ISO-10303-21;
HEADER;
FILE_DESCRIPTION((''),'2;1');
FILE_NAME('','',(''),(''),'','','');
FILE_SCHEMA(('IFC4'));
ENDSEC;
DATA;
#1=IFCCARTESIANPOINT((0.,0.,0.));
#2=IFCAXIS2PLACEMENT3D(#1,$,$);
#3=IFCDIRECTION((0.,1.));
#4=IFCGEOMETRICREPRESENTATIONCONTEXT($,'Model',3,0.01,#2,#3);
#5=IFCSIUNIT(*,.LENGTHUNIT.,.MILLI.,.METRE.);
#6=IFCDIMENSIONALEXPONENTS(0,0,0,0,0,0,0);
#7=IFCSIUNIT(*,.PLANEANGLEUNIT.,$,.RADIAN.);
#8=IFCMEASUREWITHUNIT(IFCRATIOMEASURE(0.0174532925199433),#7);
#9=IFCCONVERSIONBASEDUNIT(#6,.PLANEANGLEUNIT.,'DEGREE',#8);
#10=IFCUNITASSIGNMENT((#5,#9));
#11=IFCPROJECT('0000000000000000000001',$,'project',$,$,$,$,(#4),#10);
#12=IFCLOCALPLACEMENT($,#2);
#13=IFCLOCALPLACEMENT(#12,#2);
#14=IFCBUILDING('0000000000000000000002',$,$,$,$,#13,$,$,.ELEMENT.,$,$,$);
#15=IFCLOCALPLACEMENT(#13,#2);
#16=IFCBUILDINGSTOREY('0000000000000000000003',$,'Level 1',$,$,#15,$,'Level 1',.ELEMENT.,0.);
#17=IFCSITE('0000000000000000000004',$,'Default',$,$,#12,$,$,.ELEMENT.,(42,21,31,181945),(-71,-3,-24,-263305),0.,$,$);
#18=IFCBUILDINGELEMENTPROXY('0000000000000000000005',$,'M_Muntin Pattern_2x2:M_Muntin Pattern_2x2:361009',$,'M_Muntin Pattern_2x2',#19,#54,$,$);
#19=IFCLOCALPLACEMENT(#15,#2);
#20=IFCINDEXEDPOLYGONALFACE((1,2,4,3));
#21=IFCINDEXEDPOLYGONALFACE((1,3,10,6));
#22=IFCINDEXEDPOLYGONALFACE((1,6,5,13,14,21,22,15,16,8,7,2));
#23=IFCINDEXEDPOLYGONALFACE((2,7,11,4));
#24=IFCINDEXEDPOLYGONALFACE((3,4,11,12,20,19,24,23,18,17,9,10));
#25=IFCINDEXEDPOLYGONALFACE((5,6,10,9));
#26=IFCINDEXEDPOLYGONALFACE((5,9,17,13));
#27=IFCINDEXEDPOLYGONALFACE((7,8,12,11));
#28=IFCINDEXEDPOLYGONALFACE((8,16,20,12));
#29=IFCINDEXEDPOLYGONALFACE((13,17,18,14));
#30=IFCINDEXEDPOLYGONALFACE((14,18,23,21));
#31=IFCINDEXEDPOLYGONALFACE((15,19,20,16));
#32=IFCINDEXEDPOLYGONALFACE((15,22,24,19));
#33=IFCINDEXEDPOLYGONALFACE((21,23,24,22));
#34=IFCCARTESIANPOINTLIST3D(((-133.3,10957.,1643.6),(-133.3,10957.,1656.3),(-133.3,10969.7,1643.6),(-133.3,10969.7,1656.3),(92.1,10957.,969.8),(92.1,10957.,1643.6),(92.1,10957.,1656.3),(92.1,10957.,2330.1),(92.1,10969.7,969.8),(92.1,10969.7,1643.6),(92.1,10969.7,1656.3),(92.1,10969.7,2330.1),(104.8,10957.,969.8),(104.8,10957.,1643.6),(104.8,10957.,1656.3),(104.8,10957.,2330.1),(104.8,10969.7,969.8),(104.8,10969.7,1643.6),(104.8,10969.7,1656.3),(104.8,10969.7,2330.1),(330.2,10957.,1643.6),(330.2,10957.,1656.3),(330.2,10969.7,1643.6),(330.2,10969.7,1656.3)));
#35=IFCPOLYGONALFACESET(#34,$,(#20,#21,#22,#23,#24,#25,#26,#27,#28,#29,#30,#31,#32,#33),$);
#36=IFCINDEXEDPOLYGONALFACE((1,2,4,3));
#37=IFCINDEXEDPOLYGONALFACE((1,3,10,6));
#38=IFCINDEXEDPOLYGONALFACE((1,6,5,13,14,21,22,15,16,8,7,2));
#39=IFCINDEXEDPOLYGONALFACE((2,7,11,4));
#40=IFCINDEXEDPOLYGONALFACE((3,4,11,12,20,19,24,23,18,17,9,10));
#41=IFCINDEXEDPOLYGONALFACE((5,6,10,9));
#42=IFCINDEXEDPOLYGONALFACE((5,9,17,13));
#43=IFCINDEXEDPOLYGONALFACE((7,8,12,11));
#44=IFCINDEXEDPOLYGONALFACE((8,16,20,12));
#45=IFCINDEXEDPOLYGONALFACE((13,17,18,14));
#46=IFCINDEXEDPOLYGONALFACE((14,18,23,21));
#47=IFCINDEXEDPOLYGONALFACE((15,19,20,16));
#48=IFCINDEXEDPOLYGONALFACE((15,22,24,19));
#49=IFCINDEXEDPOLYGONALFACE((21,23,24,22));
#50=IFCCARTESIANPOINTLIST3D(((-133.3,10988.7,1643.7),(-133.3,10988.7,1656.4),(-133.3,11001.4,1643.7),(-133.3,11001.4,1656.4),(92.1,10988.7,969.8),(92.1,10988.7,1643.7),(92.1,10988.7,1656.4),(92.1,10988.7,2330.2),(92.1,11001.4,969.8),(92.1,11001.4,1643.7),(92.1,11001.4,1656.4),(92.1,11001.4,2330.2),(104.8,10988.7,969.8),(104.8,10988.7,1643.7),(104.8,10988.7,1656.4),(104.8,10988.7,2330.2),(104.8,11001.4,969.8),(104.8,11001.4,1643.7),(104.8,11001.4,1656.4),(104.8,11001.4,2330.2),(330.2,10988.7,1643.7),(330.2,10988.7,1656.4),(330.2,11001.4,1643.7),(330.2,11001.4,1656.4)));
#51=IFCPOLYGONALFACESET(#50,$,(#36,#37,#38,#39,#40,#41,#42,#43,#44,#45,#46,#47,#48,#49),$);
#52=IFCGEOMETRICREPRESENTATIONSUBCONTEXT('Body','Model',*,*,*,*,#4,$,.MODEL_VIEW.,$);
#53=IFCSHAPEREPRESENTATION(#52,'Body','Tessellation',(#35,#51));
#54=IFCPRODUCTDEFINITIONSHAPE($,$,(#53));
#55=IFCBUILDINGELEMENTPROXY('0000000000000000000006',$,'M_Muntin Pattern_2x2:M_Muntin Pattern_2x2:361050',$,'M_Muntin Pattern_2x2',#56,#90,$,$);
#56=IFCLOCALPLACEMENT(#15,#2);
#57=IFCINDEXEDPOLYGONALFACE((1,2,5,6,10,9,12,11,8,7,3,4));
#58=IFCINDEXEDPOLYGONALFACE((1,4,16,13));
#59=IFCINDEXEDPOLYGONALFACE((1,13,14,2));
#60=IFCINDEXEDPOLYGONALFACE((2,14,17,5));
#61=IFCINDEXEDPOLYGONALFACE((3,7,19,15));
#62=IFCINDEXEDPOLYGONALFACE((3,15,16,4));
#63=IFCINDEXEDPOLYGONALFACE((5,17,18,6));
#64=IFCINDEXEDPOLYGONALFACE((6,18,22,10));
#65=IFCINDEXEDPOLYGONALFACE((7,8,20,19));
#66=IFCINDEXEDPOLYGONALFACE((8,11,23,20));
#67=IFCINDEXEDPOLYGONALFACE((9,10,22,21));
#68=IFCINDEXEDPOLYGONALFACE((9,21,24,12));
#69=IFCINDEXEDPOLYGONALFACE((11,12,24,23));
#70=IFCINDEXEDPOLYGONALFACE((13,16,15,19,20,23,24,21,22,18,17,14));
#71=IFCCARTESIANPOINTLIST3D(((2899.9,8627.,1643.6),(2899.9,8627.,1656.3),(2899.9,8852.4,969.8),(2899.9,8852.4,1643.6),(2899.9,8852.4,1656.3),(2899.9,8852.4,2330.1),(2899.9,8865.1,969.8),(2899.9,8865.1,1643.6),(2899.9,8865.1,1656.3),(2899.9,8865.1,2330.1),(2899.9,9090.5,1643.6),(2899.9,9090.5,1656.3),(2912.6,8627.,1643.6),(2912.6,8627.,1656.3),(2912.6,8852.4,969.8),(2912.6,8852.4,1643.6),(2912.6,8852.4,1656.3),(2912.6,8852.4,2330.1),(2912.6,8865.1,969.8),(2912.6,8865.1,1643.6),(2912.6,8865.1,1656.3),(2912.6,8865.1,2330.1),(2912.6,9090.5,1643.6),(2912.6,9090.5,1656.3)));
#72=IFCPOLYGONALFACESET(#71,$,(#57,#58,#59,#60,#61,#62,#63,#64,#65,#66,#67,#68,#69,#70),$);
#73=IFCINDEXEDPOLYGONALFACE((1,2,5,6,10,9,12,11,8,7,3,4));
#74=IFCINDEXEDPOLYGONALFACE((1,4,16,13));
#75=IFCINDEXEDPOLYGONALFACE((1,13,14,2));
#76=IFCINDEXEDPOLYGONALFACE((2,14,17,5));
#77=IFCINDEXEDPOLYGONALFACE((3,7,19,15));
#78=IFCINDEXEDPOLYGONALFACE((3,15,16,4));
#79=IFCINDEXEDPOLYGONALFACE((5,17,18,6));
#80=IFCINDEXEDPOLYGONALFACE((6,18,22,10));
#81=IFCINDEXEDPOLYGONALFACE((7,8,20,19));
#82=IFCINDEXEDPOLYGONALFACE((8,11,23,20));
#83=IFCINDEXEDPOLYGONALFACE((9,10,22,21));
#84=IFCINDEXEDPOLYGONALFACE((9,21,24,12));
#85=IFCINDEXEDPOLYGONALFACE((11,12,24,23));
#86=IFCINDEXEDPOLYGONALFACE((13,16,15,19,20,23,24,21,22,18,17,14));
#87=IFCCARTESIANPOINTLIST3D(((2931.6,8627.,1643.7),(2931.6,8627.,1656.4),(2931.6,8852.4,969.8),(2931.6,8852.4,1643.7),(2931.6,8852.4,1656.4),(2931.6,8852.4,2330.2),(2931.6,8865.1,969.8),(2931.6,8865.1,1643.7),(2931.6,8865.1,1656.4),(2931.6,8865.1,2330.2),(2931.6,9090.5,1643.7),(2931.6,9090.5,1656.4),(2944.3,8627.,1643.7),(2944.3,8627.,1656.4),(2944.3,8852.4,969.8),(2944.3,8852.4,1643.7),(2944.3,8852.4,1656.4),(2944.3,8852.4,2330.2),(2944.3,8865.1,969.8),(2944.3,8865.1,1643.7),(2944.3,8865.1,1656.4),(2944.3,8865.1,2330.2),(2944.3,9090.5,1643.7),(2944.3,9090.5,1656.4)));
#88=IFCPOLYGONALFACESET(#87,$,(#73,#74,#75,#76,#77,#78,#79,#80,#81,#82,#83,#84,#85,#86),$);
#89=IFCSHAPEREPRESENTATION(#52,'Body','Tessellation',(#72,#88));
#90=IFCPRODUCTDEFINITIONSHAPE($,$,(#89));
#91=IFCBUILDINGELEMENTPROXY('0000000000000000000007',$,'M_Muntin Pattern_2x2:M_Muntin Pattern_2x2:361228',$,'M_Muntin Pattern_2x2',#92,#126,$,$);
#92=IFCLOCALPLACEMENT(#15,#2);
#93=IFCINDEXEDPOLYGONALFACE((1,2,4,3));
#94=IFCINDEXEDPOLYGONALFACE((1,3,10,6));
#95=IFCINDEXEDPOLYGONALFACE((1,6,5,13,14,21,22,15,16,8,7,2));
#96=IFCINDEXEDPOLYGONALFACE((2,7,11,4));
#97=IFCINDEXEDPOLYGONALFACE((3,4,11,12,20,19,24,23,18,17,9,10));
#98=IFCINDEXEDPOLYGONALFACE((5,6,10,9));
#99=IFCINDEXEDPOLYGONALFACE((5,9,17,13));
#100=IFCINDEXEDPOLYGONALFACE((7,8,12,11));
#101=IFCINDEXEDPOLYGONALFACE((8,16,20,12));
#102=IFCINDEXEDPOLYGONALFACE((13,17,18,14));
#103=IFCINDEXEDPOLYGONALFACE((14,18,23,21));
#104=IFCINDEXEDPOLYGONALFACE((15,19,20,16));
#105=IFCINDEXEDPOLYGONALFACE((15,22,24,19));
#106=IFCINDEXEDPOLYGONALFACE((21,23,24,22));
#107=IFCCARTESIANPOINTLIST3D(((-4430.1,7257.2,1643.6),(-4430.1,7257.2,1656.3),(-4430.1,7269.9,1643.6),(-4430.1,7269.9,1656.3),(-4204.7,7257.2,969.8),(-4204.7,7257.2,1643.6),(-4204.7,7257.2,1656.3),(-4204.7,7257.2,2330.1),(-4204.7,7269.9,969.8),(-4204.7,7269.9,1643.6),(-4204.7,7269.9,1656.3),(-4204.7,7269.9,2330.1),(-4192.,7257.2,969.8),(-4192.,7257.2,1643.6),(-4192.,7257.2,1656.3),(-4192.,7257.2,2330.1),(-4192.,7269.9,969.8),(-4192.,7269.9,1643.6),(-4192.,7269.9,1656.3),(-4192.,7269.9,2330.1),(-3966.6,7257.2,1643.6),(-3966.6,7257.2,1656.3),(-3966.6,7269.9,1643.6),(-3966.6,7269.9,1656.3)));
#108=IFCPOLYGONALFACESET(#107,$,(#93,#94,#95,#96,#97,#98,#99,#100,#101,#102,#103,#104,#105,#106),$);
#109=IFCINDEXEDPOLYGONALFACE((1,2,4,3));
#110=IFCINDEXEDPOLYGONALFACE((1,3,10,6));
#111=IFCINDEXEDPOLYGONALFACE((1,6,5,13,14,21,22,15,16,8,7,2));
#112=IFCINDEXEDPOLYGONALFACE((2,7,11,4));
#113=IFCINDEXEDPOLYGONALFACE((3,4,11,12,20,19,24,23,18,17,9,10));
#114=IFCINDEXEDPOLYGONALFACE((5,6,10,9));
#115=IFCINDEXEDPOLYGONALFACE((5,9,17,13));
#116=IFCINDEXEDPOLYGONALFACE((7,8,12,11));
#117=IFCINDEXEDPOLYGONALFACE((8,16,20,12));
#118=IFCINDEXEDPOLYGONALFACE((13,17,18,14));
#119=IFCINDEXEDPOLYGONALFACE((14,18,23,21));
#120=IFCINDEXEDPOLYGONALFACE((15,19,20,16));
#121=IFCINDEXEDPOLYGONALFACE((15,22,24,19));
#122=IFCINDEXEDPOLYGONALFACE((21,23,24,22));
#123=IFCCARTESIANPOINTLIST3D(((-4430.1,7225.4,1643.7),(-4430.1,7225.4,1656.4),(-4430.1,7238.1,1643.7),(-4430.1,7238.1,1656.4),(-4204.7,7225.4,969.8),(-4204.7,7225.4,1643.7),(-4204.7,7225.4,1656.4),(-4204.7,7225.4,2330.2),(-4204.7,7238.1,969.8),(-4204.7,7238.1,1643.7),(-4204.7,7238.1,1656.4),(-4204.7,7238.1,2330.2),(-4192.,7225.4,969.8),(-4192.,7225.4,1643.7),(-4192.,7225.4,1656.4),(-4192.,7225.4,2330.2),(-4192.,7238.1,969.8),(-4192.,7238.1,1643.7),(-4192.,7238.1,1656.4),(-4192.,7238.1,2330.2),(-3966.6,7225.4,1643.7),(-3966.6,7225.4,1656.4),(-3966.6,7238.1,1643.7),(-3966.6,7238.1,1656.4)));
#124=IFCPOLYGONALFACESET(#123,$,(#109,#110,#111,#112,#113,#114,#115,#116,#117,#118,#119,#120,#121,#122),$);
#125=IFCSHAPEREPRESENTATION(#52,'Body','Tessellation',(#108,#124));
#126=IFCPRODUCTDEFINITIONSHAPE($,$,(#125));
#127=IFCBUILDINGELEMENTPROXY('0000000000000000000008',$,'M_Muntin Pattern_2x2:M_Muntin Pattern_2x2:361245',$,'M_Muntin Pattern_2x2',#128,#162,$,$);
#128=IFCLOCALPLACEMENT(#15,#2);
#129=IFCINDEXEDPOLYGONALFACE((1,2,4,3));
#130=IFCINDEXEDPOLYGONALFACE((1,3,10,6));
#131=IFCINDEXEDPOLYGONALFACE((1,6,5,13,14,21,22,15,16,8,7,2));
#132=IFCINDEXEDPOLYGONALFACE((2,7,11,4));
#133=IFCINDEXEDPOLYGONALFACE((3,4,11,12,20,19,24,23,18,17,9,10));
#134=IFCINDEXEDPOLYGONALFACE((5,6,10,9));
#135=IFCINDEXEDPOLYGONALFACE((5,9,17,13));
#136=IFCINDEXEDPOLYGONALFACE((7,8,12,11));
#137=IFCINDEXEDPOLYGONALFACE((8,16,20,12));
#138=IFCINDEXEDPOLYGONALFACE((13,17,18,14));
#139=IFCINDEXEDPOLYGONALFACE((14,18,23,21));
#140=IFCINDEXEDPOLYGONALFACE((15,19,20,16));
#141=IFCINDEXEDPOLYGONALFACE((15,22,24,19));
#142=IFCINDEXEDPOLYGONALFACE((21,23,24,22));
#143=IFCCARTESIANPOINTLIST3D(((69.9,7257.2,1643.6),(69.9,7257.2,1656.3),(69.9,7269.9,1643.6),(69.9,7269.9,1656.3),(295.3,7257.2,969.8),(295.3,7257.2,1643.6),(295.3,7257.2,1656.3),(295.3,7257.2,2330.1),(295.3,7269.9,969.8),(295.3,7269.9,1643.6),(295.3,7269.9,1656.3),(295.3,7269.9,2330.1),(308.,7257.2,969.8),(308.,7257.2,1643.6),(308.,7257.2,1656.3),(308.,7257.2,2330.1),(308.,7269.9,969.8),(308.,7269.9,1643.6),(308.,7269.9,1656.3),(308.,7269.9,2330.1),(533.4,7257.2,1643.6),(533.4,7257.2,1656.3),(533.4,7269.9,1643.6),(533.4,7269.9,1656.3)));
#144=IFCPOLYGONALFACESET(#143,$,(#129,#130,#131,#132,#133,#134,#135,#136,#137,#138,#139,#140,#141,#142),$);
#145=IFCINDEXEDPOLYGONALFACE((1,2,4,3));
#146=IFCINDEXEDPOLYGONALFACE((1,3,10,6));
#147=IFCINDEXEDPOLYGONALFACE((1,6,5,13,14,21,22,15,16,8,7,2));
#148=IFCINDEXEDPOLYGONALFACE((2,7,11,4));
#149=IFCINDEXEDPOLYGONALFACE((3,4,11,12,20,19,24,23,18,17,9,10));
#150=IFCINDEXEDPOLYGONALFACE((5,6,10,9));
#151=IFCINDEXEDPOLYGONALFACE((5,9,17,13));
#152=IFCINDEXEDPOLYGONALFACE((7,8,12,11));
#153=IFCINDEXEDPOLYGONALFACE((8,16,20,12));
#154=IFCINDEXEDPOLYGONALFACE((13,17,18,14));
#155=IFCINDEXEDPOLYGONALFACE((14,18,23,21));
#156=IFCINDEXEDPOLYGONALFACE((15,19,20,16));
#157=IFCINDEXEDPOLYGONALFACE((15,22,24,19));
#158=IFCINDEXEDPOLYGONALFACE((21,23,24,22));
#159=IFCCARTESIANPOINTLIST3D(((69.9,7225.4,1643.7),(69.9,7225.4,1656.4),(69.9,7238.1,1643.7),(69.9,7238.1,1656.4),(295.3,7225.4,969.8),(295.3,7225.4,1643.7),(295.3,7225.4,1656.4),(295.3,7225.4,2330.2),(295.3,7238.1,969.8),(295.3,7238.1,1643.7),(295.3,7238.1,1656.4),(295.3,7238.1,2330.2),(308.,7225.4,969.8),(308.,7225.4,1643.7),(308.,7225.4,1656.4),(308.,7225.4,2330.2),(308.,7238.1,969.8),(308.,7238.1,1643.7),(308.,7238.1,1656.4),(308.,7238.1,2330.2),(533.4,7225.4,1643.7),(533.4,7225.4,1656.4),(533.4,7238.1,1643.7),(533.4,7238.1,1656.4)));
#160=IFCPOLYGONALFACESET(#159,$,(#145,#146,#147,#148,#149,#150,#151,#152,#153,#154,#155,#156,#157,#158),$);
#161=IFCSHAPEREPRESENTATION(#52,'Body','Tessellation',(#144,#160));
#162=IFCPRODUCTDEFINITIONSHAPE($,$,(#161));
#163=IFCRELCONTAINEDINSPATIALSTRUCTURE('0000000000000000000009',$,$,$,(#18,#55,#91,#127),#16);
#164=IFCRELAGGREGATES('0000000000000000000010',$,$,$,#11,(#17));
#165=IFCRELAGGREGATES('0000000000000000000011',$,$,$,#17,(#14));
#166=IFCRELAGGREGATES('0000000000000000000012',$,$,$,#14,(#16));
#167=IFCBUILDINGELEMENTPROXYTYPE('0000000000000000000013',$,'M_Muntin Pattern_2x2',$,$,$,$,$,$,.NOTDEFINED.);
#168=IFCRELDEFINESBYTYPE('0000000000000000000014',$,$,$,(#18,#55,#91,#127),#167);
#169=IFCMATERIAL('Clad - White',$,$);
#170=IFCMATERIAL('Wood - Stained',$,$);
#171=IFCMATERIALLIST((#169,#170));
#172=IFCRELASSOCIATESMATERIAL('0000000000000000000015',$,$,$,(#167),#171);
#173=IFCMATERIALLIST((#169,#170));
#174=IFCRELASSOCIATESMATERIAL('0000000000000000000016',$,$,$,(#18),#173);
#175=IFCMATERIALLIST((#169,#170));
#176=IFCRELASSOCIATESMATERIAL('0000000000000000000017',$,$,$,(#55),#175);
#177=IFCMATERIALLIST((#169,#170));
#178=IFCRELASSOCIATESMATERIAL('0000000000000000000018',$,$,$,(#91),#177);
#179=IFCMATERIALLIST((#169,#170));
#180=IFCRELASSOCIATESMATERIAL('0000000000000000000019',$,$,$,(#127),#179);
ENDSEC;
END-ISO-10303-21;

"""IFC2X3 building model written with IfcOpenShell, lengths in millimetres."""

from ifc_helpers import new_model, entity, si_unit, converted_unit, direction, frame, origin, place, context, subcontext, project, spatial, polyline, outline, extrude, source, transform, mapped, material, material_list, type_object, type_shapes, element, save


model = new_model("IFC2X3")

# Units and contexts
model_context = context("Model", 3, precision=0.01, world=origin(), true_north=direction((0.0, 1.0)))
body_context = subcontext(model_context, "Body", "Model", "MODEL_VIEW")
ifc_project = project(units=[si_unit("LENGTHUNIT", "METRE", prefix="MILLI"), converted_unit("PLANEANGLEUNIT", "DEGREE", entity("IfcRatioMeasure", 0.0174532925199433), si_unit("PLANEANGLEUNIT", "RADIAN"), dimensions=[0, 0, 0, 0, 0, 0, 0])], contexts=[model_context])

# Site, building, storey
site_placement = place(None, origin())
site = spatial("IfcSite", under=ifc_project, at=site_placement, Name="Default", CompositionType="ELEMENT", RefLatitude=(42, 21, 31, 181945), RefLongitude=(-71, -3, -24, -263305), RefElevation=0.0)
building_placement = place(site_placement, origin())
building = spatial("IfcBuilding", under=site, at=building_placement, CompositionType="ELEMENT")
storey_placement = place(building_placement, origin())
storey = spatial("IfcBuildingStorey", under=building, at=storey_placement, Name="Level 1", LongName="Level 1", CompositionType="ELEMENT", Elevation=0.0)

# Building element proxies
ifc_material_1 = material(Name="Clad - White")
ifc_material_2 = material(Name="Wood - Stained")
ifc_material_list_1 = material_list([ifc_material_1, ifc_material_2])
building_element_proxy_type_1 = type_object("IfcBuildingElementProxyType", Name="M_Muntin Pattern_2x2", PredefinedType="NOTDEFINED", material=ifc_material_list_1)
shared_shape_1 = source(origin(), body_context, "Body", "SweptSolid", [
    extrude(outline(polyline([(6.4, -6.4), (680.1, -6.4), (680.1, 6.3), (6.4, 6.3), (6.4, 231.7), (-6.3, 231.7), (-6.3, 6.3), (-680.2, 6.3), (-680.2, -6.4), (-6.3, -6.4), (-6.3, -231.7), (6.4, -231.7), (6.4, -6.4)])), frame((0.0, 9.5, 680.1), z_axis=(0.0, 1.0, 0.0), x_axis=(0.0, 0.0, 1.0)), (0.0, 0.0, 1.0), 12.7),
    extrude(outline(polyline([(6.4, -6.4), (680.2, -6.4), (680.2, 6.3), (6.4, 6.3), (6.4, 231.7), (-6.3, 231.7), (-6.3, 6.3), (-680.2, 6.3), (-680.2, -6.4), (-6.3, -6.4), (-6.3, -231.7), (6.4, -231.7), (6.4, -6.4)])), frame((0.0, -22.2, 680.2), z_axis=(0.0, 1.0, 0.0), x_axis=(0.0, 0.0, 1.0)), (0.0, 0.0, 1.0), 12.7),
])
type_shapes(building_element_proxy_type_1, [shared_shape_1])
ifc_material_list_2 = material_list([ifc_material_1, ifc_material_2])
proxy_1_placement = place(storey_placement, frame((98.5, 10979.2, 969.8), z_axis=(0.0, 0.0, 1.0), x_axis=(-1.0, 0.0, 0.0)))
element("IfcBuildingElementProxy", 1, at=proxy_1_placement, inside=storey, type_object=building_element_proxy_type_1, material=ifc_material_list_2, Name="M_Muntin Pattern_2x2:M_Muntin Pattern_2x2:361009", ObjectType="M_Muntin Pattern_2x2", context=body_context, shape_type="MappedRepresentation", body=[
    mapped(shared_shape_1, transform((0.0, 0.0, 0.0), scale=1.0)),
])
ifc_material_list_3 = material_list([ifc_material_1, ifc_material_2])
proxy_2_placement = place(storey_placement, frame((2922.1, 8858.7, 969.8), z_axis=(0.0, 0.0, 1.0), x_axis=(0.0, 1.0, 0.0)))
element("IfcBuildingElementProxy", 2, at=proxy_2_placement, inside=storey, type_object=building_element_proxy_type_1, material=ifc_material_list_3, Name="M_Muntin Pattern_2x2:M_Muntin Pattern_2x2:361050", ObjectType="M_Muntin Pattern_2x2", context=body_context, shape_type="MappedRepresentation", body=[
    mapped(shared_shape_1, transform((0.0, 0.0, 0.0), scale=1.0)),
])
ifc_material_list_4 = material_list([ifc_material_1, ifc_material_2])
proxy_3_placement = place(storey_placement, frame((-4198.4, 7247.6, 969.8)))
element("IfcBuildingElementProxy", 3, at=proxy_3_placement, inside=storey, type_object=building_element_proxy_type_1, material=ifc_material_list_4, Name="M_Muntin Pattern_2x2:M_Muntin Pattern_2x2:361228", ObjectType="M_Muntin Pattern_2x2", context=body_context, shape_type="MappedRepresentation", body=[
    mapped(shared_shape_1, transform((0.0, 0.0, 0.0), scale=1.0)),
])
ifc_material_list_5 = material_list([ifc_material_1, ifc_material_2])
proxy_4_placement = place(storey_placement, frame((301.6, 7247.6, 969.8)))
element("IfcBuildingElementProxy", 4, at=proxy_4_placement, inside=storey, type_object=building_element_proxy_type_1, material=ifc_material_list_5, Name="M_Muntin Pattern_2x2:M_Muntin Pattern_2x2:361245", ObjectType="M_Muntin Pattern_2x2", context=body_context, shape_type="MappedRepresentation", body=[
    mapped(shared_shape_1, transform((0.0, 0.0, 0.0), scale=1.0)),
])

save(model, "model.ifc")
